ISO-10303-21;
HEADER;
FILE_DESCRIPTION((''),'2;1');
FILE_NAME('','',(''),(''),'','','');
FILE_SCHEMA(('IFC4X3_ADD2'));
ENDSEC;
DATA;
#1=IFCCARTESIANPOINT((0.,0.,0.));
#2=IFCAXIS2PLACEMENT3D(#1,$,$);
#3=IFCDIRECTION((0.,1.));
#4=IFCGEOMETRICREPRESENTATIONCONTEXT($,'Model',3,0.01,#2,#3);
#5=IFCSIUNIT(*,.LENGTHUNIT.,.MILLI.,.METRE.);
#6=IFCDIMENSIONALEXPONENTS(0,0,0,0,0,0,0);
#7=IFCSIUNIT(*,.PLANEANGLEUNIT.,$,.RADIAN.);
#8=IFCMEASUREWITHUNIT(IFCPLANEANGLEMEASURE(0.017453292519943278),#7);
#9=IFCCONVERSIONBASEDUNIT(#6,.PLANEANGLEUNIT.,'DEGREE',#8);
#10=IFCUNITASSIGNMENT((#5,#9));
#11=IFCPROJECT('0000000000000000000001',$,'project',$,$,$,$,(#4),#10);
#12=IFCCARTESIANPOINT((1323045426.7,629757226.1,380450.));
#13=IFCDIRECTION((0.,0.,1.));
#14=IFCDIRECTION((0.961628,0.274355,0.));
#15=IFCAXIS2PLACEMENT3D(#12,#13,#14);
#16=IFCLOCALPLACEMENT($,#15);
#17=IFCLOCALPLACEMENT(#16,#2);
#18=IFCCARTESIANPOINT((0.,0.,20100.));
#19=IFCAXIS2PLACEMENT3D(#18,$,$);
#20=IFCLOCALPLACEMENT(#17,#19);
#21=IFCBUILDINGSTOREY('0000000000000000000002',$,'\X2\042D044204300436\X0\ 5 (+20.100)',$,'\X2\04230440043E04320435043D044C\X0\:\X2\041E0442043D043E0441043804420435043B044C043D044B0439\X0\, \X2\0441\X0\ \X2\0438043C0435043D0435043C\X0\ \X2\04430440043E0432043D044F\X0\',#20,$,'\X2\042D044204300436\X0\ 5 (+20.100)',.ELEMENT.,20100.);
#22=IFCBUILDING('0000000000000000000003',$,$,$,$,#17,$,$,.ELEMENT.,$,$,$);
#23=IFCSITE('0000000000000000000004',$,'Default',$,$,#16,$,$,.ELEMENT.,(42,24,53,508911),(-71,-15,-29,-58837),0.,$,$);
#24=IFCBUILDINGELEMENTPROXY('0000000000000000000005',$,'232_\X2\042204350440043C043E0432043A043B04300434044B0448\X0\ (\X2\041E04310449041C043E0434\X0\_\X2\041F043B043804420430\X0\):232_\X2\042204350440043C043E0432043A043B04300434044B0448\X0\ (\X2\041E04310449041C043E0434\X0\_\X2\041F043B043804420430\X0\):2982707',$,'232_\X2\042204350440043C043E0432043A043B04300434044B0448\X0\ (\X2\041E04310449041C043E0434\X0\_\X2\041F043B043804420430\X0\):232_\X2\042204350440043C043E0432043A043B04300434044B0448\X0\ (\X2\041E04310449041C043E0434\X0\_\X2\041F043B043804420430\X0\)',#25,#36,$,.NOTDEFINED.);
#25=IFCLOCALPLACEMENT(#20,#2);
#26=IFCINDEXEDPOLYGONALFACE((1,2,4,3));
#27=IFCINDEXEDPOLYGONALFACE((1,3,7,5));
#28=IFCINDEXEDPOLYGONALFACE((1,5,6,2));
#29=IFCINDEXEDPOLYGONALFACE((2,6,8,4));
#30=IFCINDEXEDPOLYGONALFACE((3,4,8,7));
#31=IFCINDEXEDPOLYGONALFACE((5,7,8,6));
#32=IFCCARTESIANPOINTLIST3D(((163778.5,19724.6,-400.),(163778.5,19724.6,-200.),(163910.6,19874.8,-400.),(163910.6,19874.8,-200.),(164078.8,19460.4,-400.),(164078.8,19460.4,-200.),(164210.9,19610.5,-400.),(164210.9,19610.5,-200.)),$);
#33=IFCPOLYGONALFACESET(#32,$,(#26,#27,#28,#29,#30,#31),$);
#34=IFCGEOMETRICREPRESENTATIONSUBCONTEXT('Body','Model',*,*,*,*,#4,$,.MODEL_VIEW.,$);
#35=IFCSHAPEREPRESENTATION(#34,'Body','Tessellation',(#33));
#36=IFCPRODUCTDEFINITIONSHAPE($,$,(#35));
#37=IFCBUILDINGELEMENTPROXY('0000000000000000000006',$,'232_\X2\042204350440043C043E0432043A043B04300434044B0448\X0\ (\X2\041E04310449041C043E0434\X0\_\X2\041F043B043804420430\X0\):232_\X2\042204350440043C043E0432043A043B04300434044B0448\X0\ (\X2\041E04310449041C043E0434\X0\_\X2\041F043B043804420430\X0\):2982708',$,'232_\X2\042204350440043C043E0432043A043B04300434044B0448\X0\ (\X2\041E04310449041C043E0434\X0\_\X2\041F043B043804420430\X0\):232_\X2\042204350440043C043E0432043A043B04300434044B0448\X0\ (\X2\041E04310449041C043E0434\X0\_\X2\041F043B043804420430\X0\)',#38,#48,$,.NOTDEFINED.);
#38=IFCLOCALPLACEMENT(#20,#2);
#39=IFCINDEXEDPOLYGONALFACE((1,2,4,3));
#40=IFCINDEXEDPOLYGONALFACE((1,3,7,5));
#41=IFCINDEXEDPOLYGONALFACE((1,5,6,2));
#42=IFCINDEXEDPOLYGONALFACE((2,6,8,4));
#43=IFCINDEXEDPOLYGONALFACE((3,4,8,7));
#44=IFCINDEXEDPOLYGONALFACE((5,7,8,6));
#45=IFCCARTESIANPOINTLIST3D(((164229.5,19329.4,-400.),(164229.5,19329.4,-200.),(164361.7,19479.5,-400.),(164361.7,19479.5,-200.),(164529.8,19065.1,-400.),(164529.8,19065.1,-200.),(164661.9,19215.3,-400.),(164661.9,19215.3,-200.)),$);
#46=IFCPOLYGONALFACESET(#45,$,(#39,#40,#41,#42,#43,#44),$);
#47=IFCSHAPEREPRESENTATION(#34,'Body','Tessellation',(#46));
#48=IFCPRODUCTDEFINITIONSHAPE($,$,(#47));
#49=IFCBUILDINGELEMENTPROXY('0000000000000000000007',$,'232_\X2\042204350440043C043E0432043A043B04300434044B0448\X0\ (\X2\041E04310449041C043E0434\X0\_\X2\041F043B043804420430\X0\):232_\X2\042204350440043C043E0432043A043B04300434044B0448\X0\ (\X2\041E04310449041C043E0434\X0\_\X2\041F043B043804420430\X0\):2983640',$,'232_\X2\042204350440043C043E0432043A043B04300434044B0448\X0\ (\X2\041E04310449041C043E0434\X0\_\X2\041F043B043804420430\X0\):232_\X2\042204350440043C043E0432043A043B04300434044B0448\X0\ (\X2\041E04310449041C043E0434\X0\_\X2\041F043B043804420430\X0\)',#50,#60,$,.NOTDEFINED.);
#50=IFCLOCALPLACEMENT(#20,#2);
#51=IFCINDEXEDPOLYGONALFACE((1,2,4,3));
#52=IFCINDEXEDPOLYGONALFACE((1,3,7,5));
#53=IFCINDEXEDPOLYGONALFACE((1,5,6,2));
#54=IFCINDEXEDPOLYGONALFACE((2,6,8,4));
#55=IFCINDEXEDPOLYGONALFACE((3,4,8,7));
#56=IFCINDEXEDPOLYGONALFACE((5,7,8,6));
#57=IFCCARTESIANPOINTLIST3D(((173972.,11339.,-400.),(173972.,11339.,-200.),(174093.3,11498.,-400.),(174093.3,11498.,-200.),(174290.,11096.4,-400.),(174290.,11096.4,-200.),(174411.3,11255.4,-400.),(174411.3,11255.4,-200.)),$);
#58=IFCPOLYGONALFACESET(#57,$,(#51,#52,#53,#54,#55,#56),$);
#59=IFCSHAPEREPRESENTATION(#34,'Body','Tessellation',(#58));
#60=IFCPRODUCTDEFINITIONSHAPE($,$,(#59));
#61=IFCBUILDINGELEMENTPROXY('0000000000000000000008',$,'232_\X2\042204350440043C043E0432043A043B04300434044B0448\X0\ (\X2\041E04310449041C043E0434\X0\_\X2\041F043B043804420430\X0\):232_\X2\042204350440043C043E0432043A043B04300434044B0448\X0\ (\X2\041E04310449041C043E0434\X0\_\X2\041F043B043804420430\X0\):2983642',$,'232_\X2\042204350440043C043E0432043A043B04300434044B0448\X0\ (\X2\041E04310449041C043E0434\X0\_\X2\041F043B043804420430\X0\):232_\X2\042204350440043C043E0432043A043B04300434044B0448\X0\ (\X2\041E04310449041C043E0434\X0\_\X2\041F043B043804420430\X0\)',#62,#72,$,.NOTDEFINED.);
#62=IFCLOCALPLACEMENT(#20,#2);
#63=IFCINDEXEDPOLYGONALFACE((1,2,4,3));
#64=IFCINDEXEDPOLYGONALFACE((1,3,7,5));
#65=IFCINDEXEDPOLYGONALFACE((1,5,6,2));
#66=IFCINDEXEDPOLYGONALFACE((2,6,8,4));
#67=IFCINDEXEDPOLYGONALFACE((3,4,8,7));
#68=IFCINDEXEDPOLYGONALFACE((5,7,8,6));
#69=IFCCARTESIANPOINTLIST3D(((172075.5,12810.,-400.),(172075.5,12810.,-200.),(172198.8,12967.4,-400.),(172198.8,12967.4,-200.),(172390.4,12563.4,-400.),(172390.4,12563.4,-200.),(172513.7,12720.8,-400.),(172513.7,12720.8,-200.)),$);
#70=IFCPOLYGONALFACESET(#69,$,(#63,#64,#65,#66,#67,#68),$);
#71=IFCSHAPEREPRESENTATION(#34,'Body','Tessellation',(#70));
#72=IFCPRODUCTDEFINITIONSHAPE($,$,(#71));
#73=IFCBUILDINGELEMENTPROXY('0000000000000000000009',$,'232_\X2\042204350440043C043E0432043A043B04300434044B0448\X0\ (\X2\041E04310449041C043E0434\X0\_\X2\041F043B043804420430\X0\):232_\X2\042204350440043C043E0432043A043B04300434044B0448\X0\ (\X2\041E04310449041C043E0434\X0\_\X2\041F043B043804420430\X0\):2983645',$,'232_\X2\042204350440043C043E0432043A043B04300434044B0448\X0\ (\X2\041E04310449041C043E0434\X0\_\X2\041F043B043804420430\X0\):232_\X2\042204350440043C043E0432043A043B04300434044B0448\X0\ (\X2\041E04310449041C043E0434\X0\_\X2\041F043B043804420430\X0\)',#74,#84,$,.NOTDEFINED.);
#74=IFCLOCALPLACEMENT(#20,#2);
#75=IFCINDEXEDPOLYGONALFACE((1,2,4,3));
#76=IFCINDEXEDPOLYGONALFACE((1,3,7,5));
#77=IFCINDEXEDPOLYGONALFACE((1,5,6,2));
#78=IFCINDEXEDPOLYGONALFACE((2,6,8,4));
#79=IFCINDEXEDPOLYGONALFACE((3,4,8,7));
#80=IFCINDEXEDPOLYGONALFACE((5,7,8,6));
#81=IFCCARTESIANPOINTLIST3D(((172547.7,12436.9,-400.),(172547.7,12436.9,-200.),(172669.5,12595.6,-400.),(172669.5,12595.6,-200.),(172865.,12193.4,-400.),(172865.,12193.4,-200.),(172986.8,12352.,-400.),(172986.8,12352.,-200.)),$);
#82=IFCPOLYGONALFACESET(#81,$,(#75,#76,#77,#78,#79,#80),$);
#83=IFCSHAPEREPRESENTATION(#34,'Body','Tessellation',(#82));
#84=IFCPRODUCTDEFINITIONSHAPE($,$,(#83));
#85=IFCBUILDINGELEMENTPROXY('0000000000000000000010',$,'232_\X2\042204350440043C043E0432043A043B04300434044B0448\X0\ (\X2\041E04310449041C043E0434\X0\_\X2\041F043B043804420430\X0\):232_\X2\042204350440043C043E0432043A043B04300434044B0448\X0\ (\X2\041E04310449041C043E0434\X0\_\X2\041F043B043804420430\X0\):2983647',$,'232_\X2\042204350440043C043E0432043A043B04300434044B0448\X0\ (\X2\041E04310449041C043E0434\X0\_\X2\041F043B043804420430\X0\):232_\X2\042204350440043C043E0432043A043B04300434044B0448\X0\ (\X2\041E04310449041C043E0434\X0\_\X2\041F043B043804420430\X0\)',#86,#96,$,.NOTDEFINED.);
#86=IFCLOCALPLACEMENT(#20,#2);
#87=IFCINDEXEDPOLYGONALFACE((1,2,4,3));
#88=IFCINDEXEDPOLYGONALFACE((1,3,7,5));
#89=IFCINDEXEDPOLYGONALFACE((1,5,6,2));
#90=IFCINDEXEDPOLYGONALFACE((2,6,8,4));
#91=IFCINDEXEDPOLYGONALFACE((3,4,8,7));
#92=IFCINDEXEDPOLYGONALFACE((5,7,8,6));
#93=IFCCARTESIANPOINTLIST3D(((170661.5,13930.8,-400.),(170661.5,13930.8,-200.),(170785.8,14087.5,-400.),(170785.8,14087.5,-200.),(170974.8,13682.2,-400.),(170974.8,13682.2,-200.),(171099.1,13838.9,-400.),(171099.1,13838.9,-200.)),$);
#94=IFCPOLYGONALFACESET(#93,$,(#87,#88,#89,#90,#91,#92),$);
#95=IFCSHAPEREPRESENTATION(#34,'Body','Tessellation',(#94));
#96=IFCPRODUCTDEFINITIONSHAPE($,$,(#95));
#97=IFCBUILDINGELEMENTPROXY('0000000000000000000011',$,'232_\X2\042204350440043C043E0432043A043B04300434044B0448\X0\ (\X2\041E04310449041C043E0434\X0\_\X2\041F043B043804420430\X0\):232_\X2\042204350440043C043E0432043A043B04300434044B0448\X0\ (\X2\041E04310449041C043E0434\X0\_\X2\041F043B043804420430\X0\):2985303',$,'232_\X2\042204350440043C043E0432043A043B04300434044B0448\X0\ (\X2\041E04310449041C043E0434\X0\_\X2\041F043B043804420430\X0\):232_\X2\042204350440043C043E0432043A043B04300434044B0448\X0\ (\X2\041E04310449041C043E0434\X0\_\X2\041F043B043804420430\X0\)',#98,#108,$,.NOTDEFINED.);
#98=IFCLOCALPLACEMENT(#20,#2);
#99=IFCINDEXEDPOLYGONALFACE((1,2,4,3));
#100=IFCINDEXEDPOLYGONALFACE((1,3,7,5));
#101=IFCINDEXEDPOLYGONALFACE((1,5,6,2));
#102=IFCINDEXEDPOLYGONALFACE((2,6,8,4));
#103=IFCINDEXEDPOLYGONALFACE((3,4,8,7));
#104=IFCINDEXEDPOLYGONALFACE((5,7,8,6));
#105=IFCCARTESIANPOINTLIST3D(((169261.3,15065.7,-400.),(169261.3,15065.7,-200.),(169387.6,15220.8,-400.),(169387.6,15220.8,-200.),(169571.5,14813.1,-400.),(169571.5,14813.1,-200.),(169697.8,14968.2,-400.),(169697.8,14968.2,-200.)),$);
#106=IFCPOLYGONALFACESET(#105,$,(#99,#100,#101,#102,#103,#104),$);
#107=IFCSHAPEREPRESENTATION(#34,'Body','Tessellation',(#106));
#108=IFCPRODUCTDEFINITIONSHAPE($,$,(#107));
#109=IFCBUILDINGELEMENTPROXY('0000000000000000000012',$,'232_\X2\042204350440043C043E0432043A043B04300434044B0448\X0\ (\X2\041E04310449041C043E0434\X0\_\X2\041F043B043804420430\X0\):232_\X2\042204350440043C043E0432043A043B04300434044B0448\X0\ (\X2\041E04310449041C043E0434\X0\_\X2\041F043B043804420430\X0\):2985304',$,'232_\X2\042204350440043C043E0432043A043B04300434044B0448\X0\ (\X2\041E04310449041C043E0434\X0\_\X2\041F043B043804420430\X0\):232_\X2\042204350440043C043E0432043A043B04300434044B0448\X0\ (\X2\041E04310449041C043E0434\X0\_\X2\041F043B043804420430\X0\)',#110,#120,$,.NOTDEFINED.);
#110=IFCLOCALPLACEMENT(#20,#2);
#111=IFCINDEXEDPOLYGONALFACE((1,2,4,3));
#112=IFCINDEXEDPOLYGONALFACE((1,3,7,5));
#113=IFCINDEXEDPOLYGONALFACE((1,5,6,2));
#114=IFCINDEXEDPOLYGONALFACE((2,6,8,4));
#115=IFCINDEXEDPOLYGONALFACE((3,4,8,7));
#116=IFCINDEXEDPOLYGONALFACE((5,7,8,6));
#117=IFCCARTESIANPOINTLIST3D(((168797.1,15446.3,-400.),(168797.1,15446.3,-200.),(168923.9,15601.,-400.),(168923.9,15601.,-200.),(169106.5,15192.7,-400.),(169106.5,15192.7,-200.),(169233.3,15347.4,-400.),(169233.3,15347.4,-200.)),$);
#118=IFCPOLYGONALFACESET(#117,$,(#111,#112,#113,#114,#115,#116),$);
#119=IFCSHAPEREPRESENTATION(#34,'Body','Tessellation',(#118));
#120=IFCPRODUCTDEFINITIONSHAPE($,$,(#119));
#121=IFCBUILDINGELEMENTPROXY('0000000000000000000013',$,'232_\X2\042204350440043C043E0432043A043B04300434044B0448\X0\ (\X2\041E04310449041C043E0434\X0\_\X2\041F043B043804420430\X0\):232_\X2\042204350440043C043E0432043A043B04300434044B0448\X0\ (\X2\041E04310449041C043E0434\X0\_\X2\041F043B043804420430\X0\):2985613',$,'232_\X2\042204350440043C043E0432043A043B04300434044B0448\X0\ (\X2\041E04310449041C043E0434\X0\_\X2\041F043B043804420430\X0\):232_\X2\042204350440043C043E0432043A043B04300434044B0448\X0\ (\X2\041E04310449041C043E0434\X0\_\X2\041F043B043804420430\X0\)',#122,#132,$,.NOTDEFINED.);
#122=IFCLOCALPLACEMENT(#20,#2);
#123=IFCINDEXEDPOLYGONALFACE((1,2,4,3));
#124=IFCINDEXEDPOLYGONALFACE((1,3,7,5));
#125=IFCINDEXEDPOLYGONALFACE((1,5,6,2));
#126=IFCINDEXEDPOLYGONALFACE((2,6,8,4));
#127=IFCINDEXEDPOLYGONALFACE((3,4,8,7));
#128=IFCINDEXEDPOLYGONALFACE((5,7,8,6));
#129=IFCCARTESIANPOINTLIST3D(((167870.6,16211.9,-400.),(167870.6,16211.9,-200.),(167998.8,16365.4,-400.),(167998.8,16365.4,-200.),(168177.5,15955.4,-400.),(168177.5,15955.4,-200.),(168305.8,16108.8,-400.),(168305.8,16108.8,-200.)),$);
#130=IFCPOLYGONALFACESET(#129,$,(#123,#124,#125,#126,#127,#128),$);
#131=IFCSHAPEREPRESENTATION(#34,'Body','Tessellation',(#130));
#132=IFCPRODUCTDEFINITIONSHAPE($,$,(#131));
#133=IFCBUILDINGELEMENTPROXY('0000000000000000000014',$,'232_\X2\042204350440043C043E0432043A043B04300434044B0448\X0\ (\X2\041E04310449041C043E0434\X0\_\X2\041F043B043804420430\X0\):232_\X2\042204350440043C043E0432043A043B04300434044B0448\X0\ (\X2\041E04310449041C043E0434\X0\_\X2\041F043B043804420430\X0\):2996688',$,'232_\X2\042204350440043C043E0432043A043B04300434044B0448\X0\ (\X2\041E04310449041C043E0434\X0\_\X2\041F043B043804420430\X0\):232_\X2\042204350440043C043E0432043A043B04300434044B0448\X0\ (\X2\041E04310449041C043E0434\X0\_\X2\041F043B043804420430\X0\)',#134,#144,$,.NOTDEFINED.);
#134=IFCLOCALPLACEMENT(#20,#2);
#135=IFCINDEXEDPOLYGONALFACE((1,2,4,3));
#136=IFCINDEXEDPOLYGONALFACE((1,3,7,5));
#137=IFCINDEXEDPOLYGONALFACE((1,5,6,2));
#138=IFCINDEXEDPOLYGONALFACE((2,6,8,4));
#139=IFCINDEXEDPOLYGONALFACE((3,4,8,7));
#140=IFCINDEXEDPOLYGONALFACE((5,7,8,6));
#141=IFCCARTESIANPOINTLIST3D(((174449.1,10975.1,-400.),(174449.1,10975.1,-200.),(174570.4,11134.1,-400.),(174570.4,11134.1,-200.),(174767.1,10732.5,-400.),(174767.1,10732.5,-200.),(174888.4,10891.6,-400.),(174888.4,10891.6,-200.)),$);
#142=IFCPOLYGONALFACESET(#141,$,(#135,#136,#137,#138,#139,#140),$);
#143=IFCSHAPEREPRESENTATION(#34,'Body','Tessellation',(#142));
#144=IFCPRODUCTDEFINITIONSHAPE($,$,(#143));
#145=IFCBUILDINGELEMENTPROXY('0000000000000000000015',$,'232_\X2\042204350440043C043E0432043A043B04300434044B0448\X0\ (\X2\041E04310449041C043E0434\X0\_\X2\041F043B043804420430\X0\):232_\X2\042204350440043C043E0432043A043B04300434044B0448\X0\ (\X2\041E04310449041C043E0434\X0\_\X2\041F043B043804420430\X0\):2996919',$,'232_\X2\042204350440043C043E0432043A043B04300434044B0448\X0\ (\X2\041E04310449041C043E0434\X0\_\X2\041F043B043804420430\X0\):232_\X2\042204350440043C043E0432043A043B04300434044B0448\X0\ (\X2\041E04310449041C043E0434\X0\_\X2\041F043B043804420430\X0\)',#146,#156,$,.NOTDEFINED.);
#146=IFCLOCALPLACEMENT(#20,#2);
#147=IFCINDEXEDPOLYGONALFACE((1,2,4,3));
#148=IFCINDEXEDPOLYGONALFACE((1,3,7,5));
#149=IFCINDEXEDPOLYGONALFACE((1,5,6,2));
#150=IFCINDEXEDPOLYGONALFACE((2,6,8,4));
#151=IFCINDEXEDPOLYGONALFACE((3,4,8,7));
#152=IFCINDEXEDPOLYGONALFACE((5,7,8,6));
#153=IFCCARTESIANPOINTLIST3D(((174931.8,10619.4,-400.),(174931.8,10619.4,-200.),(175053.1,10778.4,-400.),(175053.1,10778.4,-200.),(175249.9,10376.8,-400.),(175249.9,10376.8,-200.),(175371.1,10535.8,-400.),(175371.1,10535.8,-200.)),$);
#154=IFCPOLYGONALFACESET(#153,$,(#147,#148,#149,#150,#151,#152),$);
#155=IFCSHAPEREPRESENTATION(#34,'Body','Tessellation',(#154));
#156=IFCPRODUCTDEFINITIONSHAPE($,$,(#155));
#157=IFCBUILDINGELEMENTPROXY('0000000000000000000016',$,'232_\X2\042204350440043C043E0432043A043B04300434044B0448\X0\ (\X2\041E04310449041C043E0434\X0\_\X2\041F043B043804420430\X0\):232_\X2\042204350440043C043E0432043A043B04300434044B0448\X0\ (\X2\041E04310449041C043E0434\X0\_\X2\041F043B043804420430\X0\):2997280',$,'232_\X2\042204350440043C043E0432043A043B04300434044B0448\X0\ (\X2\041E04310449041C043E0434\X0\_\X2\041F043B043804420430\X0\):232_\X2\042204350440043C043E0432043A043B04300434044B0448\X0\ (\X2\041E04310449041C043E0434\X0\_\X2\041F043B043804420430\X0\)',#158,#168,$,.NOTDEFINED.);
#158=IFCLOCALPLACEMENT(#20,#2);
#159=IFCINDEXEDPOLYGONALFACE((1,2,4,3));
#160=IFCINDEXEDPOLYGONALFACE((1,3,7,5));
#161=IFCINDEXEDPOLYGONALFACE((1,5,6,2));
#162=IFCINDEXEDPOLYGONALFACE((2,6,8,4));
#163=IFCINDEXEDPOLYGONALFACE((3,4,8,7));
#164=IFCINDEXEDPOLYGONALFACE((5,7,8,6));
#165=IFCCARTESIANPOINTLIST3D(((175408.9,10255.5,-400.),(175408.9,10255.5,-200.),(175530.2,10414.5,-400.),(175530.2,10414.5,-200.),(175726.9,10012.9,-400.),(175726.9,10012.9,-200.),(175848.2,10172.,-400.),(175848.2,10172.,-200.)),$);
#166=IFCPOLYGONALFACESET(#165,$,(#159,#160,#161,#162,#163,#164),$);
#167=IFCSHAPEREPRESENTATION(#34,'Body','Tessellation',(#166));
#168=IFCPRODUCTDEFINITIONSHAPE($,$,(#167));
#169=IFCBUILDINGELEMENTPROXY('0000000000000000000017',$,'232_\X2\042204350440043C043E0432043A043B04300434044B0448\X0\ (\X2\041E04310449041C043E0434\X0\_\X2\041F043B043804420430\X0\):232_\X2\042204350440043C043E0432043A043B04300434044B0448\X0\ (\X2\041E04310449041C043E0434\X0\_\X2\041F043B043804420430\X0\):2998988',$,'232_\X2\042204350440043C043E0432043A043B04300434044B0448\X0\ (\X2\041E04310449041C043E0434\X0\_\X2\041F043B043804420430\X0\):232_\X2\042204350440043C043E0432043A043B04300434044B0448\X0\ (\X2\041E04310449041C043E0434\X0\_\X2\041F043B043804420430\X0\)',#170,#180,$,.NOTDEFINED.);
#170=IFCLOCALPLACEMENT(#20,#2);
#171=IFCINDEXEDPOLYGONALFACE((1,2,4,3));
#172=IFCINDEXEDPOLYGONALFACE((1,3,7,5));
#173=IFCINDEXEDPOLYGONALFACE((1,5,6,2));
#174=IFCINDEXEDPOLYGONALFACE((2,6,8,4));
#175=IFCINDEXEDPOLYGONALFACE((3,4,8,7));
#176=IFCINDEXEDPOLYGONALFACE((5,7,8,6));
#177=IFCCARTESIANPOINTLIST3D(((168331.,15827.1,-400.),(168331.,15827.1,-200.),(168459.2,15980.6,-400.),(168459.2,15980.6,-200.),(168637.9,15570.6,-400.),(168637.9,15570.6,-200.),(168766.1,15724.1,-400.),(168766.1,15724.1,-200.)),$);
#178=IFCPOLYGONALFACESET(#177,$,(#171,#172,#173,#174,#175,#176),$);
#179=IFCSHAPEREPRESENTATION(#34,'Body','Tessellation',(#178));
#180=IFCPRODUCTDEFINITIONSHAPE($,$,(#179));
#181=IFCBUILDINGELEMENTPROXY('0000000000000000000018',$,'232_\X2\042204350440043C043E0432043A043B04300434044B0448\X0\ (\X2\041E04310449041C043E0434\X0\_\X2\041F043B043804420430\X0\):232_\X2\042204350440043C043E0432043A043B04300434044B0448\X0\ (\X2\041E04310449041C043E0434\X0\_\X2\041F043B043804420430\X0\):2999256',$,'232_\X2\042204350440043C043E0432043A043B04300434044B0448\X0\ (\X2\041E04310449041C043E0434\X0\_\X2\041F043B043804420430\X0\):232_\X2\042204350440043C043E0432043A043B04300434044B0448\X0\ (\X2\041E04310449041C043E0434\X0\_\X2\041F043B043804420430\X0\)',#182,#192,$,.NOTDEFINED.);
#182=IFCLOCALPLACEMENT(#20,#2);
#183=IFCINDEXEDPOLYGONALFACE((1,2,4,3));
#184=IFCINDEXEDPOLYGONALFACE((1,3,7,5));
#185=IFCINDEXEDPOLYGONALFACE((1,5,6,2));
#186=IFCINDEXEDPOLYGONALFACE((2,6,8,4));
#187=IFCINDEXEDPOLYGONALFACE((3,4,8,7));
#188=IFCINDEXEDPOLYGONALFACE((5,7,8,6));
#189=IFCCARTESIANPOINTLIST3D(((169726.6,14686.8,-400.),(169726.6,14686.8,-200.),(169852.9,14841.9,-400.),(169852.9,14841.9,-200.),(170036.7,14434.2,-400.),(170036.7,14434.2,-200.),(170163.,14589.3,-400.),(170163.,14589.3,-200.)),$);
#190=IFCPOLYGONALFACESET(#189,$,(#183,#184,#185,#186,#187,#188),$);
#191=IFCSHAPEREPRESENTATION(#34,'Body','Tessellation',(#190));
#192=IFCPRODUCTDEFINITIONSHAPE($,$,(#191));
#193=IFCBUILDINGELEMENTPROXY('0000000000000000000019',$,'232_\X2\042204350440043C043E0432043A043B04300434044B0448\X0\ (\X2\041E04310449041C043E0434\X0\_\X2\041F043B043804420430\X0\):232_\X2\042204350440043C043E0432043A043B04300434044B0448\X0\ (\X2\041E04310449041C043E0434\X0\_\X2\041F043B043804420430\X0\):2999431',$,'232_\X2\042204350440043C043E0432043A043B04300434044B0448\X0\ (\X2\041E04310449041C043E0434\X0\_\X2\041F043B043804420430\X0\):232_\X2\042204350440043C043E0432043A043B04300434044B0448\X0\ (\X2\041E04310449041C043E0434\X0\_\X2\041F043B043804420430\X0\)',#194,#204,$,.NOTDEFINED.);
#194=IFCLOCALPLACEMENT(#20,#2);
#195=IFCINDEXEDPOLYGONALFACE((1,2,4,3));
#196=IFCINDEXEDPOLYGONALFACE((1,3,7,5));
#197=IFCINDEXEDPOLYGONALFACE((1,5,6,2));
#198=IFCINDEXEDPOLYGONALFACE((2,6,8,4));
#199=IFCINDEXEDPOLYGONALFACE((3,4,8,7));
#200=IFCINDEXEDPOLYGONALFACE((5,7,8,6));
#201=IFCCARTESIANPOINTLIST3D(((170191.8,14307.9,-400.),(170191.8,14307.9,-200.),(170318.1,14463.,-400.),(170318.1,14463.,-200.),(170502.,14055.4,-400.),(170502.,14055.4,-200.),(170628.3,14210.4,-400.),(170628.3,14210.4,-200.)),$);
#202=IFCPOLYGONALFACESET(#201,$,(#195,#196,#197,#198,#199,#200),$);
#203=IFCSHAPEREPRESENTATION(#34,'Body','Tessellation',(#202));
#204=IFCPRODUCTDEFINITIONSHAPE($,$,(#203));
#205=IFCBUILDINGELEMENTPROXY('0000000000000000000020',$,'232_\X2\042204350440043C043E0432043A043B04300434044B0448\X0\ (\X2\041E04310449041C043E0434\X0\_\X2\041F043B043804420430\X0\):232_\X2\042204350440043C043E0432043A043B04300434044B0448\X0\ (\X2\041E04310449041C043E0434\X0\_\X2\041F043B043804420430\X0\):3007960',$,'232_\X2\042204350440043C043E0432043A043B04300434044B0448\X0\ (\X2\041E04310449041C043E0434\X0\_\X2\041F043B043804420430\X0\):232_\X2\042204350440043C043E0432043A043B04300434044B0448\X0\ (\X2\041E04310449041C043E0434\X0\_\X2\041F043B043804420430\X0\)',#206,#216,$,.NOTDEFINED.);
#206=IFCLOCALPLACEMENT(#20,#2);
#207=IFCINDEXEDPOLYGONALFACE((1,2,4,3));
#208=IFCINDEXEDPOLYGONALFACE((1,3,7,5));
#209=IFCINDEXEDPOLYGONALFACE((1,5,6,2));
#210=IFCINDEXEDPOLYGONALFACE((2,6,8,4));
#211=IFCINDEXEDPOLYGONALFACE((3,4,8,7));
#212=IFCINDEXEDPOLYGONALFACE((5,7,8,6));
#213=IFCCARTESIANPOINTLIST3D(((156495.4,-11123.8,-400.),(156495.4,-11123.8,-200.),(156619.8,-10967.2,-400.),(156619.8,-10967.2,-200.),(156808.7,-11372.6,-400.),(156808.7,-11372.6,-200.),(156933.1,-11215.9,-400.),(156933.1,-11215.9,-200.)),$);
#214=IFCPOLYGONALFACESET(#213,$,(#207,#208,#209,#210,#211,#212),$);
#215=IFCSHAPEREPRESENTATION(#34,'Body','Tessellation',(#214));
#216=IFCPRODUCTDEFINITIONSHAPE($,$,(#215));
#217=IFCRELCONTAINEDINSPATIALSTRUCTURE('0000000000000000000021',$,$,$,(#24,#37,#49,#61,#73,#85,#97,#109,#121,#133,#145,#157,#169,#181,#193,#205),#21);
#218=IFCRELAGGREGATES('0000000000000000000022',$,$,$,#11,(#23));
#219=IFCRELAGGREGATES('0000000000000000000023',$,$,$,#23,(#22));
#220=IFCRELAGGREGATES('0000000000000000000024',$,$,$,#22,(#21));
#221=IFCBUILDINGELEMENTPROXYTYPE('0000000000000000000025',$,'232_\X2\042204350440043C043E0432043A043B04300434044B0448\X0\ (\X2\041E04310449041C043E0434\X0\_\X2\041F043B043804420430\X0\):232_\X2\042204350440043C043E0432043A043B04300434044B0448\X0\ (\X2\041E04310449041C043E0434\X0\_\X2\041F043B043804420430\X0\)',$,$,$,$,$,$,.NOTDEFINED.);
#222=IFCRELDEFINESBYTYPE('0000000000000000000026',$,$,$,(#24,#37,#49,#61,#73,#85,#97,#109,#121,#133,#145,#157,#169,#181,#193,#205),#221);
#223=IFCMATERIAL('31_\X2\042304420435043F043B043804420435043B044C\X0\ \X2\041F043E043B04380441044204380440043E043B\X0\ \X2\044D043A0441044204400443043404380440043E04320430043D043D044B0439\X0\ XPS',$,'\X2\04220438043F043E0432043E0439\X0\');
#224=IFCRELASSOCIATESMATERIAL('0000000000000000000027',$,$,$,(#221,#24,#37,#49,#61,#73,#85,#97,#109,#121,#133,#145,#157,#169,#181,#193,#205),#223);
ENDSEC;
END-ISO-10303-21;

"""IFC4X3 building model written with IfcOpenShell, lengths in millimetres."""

from ifc_helpers import new_model, entity, si_unit, converted_unit, direction, frame, origin, origin_2d_with_axis, place, context, subcontext, project, spatial, rectangle, extrude, source, transform, mapped, material, type_object, type_shapes, element, save


model = new_model("IFC4X3")

# Units and contexts
model_context = context("Model", 3, precision=0.01, world=origin(), true_north=direction((0.0, 1.0)))
body_context = subcontext(model_context, "Body", "Model", "MODEL_VIEW")
ifc_project = project(units=[si_unit("LENGTHUNIT", "METRE", prefix="MILLI"), converted_unit("PLANEANGLEUNIT", "DEGREE", entity("IfcPlaneAngleMeasure", 0.017453292519943278), si_unit("PLANEANGLEUNIT", "RADIAN"), dimensions=[0, 0, 0, 0, 0, 0, 0])], contexts=[model_context])

# Site, building, storey
site_placement = place(None, frame((1323045426.7, 629757226.1, 380450.0), z_axis=(0.0, 0.0, 1.0), x_axis=(0.961628, 0.274355, 0.0)))
site = spatial("IfcSite", under=ifc_project, at=site_placement, Name="Default", CompositionType="ELEMENT", RefLatitude=(42, 24, 53, 508911), RefLongitude=(-71, -15, -29, -58837), RefElevation=0.0)
building_placement = place(site_placement, origin())
building = spatial("IfcBuilding", under=site, at=building_placement, CompositionType="ELEMENT")
storey_placement = place(building_placement, frame((0.0, 0.0, 20100.0)))
storey = spatial("IfcBuildingStorey", under=building, at=storey_placement, Name="Этаж 5 (+20.100)", ObjectType="Уровень:Относительный, с именем уровня", LongName="Этаж 5 (+20.100)", CompositionType="ELEMENT", Elevation=20100.0)

# Building element proxies
ifc_material = material(Name="31_Утеплитель Полистирол экструдированный XPS", Category="Типовой")
building_element_proxy_type_1 = type_object("IfcBuildingElementProxyType", Name="232_Термовкладыш (ОбщМод_Плита):232_Термовкладыш (ОбщМод_Плита)", PredefinedType="NOTDEFINED", material=ifc_material)
shared_shape_1 = source(origin(), body_context, "Body", "SweptSolid", [
    extrude(rectangle(XDim=400.0, YDim=200.0, at=origin_2d_with_axis()), frame((200.0, 0.0, -200.0), z_axis=(0.0, 0.0, 1.0), x_axis=(-1.0, 0.0, 0.0)), (0.0, 0.0, 1.0), 200.0),
])
type_shapes(building_element_proxy_type_1, [shared_shape_1])
for number, where, z_axis, x_axis, name in (
    (1, (164144.8, 19535.5, -200.0), (0.0, 0.0, 1.0), (-0.750696, 0.660648, 0.0), "232_Термовкладыш (ОбщМод_Плита):232_Термовкладыш (ОбщМод_Плита):2982707"),
    (2, (164595.9, 19140.2, -200.0), (0.0, 0.0, 1.0), (-0.750696, 0.660648, 0.0), "232_Термовкладыш (ОбщМод_Плита):232_Термовкладыш (ОбщМод_Плита):2982708"),
    (3, (174350.7, 11175.9, -200.0), (0.0, 0.0, 1.0), (-0.795137, 0.60643, 0.0), "232_Термовкладыш (ОбщМод_Плита):232_Термовкладыш (ОбщМод_Плита):2983640"),
    (4, (172452.1, 12642.1, -200.0), (0.0, 0.0, 1.0), (-0.787341, 0.616517, 0.0), "232_Термовкладыш (ОбщМод_Плита):232_Термовкладыш (ОбщМод_Плита):2983642"),
    (5, (172925.9, 12272.7, -200.0), (0.0, 0.0, 1.0), (-0.7932, 0.608961, 0.0), "232_Термовкладыш (ОбщМод_Плита):232_Термовкладыш (ОбщМод_Плита):2983645"),
    (6, (171037.0, 13760.5, -200.0), (0.0, 0.0, 1.0), (-0.783395, 0.621524, 0.0), "232_Термовкладыш (ОбщМод_Плита):232_Термовкладыш (ОбщМод_Плита):2983647"),
    (7, (169634.6, 14890.7, -200.0), (0.0, 0.0, 1.0), (-0.775408, 0.63146, 0.0), "232_Термовкладыш (ОбщМод_Плита):232_Термовкладыш (ОбщМод_Плита):2985303"),
    (8, (169169.9, 15270.1, -200.0), (0.0, 0.0, 1.0), (-0.773392, 0.633929, 0.0), "232_Термовкладыш (ОбщМод_Плита):232_Термовкладыш (ОбщМод_Плита):2985304"),
    (9, (168241.6, 16032.1, -200.0), (0.0, 0.0, 1.0), (-0.767295, 0.641294, 0.0), "232_Термовкладыш (ОбщМод_Плита):232_Термовкладыш (ОбщМод_Плита):2985613"),
    (10, (174827.8, 10812.0, -200.0), (0.0, 0.0, 1.0), (-0.795137, 0.60643, 0.0), "232_Термовкладыш (ОбщМод_Плита):232_Термовкладыш (ОбщМод_Плита):2996688"),
    (11, (175310.5, 10456.3, -200.0), (0.0, 0.0, 1.0), (-0.795137, 0.60643, 0.0), "232_Термовкладыш (ОбщМод_Плита):232_Термовкладыш (ОбщМод_Плита):2996919"),
    (12, (175787.6, 10092.5, -200.0), (0.0, 0.0, 1.0), (-0.795137, 0.60643, 0.0), "232_Термовкладыш (ОбщМод_Плита):232_Термовкладыш (ОбщМод_Плита):2997280"),
    (13, (168702.0, 15647.3, -200.0), (0.0, 0.0, 1.0), (-0.767295, 0.641294, 0.0), "232_Термовкладыш (ОбщМод_Плита):232_Термовкладыш (ОбщМод_Плита):2998988"),
    (14, (170099.9, 14511.8, -200.0), (0.0, 0.0, 1.0), (-0.775408, 0.63146, 0.0), "232_Термовкладыш (ОбщМод_Плита):232_Термовкладыш (ОбщМод_Плита):2999256"),
    (15, (170565.1, 14132.9, -200.0), (0.0, 0.0, 1.0), (-0.775408, 0.63146, 0.0), "232_Термовкладыш (ОбщМод_Плита):232_Термовкладыш (ОбщМод_Плита):2999431"),
    (16, (156557.6, -11045.5, -200.0), (0.0, 0.0, 1.0), (0.783118, -0.621873, 0.0), "232_Термовкладыш (ОбщМод_Плита):232_Термовкладыш (ОбщМод_Плита):3007960"),
):
    element("IfcBuildingElementProxy", number, at=place(storey_placement, frame(where, z_axis=z_axis, x_axis=x_axis)), inside=storey, type_object=building_element_proxy_type_1, material=ifc_material, Name=name, ObjectType="232_Термовкладыш (ОбщМод_Плита):232_Термовкладыш (ОбщМод_Плита)", PredefinedType="NOTDEFINED", context=body_context, shape_type="MappedRepresentation", body=[
        mapped(shared_shape_1, transform((0.0, 0.0, 0.0), scale=1.0)),
    ])

save(model, "model.ifc")
